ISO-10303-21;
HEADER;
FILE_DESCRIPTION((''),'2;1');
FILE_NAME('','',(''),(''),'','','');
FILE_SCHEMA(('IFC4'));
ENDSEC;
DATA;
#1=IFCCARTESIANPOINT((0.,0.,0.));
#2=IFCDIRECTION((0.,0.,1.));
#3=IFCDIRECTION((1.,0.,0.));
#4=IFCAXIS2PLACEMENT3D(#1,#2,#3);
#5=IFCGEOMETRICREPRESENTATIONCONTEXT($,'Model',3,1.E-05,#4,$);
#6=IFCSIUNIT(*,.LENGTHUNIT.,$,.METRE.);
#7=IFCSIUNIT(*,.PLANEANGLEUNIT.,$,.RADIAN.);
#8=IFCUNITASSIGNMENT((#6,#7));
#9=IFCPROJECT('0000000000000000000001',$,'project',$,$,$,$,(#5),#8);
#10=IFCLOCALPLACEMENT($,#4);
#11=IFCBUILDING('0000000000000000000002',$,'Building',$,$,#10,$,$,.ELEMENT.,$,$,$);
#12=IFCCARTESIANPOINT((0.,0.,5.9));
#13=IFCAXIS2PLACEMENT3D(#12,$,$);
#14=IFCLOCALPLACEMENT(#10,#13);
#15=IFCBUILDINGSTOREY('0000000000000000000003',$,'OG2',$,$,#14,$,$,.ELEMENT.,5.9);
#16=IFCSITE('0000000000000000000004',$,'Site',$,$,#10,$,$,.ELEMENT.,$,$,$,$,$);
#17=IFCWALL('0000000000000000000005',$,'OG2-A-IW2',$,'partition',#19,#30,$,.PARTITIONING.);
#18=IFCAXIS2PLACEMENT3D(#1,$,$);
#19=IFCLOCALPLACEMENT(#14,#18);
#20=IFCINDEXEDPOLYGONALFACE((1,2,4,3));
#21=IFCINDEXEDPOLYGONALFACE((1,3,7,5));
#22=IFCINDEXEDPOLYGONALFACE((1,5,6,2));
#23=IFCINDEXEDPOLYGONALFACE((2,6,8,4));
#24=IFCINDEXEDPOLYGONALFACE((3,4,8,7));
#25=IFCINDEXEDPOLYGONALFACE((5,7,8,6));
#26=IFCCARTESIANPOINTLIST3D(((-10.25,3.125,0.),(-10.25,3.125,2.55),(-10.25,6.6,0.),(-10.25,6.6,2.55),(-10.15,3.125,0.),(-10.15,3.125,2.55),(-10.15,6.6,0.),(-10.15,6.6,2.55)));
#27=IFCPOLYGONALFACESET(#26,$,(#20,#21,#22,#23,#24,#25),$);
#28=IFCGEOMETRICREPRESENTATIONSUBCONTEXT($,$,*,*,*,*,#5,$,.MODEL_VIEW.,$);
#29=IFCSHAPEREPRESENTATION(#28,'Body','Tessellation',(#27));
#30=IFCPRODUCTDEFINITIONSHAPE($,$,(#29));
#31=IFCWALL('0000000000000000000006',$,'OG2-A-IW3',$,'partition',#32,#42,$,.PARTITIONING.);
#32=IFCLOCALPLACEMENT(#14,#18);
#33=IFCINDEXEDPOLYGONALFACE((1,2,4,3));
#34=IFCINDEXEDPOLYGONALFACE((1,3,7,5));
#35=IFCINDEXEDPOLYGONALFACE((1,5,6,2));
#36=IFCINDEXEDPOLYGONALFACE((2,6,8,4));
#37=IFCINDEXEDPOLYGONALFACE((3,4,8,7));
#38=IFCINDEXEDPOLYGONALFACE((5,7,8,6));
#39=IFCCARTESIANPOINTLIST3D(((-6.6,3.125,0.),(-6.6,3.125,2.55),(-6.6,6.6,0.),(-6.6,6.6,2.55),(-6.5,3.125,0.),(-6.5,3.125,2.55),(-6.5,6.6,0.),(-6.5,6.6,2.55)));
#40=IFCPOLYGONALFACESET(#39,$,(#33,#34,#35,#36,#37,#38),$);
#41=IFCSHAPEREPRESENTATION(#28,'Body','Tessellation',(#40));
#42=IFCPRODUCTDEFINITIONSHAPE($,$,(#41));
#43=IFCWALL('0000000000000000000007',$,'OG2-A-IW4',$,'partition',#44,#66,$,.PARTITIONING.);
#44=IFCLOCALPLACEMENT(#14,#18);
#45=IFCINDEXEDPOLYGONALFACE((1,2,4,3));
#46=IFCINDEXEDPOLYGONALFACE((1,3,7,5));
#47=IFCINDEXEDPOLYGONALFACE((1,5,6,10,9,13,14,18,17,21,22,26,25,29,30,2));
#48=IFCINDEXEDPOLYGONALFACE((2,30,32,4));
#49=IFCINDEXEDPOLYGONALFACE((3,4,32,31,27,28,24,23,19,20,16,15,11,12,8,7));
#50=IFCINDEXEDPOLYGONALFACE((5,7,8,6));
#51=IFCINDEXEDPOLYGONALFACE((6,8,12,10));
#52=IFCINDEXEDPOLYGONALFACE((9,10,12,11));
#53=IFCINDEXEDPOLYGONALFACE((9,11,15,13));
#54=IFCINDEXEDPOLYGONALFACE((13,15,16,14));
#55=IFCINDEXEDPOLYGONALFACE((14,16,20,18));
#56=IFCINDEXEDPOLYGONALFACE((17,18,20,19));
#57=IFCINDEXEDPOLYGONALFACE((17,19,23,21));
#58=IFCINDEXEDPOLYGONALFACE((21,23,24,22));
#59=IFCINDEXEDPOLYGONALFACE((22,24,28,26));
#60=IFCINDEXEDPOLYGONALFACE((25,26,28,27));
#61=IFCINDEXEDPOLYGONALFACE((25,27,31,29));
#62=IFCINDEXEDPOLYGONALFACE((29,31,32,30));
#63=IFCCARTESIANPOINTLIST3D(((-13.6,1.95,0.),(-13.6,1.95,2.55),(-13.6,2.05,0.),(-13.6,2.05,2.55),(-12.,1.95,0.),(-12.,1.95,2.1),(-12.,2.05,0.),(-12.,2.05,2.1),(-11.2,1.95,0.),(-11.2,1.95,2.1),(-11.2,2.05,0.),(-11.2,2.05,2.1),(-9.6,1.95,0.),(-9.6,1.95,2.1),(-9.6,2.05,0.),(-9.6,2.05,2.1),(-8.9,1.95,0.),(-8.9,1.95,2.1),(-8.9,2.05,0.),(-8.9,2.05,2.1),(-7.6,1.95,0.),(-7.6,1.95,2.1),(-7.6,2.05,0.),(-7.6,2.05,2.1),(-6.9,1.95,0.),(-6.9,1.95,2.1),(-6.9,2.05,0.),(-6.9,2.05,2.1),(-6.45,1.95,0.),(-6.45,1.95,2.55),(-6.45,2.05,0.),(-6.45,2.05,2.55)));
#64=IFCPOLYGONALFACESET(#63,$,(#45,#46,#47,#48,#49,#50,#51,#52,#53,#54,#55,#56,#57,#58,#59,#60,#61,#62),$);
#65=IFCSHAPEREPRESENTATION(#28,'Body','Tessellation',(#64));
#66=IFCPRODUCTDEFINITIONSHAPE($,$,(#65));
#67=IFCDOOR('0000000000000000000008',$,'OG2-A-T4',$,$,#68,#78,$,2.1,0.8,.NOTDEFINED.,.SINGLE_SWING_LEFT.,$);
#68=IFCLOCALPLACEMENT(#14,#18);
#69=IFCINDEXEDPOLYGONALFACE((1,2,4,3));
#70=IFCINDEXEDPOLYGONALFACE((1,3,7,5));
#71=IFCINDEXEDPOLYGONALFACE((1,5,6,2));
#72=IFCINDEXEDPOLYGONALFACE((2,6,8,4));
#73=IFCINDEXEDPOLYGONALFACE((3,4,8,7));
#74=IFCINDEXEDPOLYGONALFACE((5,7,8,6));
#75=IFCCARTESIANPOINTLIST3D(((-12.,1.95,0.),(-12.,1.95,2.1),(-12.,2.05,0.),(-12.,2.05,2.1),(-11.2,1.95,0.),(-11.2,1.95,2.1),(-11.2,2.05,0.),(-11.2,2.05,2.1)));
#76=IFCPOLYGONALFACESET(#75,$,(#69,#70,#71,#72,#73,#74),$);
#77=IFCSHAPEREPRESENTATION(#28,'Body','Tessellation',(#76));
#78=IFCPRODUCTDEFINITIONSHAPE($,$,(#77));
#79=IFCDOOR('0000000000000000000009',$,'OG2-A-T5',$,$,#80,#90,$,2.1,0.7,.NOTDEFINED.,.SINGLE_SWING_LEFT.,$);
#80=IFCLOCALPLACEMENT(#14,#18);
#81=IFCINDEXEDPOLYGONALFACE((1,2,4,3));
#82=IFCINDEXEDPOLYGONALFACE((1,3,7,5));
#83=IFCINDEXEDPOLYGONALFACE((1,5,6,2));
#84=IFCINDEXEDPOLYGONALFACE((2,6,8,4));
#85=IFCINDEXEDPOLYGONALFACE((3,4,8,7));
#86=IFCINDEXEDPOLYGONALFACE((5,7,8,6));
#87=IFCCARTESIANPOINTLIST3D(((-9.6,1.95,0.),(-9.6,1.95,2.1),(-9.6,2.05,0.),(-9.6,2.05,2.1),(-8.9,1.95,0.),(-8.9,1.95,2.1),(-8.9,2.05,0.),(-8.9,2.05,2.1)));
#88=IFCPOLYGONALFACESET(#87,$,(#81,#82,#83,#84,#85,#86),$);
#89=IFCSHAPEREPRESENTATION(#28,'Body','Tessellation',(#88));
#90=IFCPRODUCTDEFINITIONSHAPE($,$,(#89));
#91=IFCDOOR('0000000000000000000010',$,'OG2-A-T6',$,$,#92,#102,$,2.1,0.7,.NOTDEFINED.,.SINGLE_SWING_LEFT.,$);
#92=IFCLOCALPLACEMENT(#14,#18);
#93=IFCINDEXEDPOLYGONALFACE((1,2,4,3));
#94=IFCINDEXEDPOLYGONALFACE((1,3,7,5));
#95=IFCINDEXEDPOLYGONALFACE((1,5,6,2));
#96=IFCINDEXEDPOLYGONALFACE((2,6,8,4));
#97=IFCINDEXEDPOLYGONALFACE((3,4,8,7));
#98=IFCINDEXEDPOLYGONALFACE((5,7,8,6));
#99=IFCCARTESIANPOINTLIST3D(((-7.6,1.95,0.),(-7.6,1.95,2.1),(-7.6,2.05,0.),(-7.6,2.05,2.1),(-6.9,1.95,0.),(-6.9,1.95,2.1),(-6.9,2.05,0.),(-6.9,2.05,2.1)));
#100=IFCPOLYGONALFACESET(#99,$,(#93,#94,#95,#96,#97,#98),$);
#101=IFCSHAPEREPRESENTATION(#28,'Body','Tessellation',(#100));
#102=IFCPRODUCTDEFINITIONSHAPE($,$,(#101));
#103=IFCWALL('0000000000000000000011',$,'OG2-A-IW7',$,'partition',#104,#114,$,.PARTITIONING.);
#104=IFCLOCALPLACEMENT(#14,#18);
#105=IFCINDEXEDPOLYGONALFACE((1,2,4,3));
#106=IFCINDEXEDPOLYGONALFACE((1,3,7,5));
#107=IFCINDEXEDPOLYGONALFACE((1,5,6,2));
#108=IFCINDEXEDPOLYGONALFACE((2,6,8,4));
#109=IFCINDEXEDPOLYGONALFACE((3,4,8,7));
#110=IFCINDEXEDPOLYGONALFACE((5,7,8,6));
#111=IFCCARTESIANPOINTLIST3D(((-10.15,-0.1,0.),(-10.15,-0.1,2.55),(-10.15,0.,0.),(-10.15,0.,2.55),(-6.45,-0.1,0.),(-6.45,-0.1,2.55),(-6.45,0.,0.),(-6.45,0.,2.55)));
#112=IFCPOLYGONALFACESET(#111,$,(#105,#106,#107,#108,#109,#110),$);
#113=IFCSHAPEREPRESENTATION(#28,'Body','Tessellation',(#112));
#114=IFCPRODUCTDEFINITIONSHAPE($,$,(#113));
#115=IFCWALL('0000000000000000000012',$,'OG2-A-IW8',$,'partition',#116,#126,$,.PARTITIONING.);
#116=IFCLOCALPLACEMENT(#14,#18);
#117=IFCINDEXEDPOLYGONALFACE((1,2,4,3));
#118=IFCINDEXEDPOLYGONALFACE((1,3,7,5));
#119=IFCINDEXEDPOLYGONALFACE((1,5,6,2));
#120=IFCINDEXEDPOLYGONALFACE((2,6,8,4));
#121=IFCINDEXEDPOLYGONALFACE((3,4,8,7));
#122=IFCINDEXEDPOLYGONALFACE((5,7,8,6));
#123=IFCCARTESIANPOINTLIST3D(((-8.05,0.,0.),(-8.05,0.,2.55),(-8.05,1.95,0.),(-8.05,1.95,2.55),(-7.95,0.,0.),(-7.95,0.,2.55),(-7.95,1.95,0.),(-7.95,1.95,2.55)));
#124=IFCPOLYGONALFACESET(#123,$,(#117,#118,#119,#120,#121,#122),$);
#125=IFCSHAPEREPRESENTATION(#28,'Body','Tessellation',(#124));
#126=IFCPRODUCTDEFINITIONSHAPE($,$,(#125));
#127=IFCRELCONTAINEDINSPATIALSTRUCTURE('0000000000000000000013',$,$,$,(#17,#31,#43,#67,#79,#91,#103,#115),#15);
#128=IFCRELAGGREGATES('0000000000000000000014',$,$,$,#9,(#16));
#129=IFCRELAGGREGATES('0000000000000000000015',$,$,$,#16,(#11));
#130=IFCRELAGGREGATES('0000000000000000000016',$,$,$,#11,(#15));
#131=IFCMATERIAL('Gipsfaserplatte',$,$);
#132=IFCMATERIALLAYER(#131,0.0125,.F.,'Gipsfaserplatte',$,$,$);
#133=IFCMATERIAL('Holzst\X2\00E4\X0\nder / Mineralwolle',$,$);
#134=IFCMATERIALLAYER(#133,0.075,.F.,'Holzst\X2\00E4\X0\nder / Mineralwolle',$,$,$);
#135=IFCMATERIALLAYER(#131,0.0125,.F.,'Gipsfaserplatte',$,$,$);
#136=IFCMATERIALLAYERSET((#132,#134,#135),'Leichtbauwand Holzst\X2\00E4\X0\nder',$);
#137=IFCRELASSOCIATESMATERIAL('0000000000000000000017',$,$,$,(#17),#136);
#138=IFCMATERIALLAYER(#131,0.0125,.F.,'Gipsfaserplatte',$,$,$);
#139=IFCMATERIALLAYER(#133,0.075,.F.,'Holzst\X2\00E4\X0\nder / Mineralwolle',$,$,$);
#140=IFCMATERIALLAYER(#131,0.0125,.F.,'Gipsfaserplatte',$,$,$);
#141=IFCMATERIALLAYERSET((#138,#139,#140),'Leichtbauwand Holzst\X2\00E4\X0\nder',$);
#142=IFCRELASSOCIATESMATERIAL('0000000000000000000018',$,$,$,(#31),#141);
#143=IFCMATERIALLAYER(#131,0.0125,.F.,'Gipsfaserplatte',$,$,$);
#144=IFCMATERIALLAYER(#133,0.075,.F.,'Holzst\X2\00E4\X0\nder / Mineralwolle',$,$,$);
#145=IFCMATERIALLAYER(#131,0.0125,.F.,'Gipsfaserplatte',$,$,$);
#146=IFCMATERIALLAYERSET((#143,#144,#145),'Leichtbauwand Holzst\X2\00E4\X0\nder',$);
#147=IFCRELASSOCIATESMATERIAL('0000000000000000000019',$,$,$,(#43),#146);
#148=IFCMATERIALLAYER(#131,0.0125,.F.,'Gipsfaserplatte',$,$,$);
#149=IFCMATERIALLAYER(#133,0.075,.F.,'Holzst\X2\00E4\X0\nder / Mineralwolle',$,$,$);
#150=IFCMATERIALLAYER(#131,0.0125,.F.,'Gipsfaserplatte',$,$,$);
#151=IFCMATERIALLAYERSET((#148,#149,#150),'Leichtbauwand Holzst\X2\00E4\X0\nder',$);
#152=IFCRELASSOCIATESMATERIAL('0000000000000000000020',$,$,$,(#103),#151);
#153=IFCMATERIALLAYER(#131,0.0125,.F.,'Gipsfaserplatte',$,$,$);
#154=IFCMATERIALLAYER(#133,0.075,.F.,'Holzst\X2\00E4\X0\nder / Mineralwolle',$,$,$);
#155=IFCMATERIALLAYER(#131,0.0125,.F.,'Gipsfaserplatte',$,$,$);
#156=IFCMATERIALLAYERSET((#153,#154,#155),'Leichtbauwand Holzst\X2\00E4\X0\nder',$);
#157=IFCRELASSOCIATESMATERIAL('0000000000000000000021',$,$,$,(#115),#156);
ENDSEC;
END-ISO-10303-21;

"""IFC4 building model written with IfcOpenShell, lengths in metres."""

from ifc_helpers import new_model, si_unit, frame, frame_2d, origin, origin_with_axes, place, context, subcontext, project, spatial, rectangle, extrude, material, layer, layer_set, element, fill, save


model = new_model("IFC4")

# Units and contexts
model_context = context("Model", 3, precision=1e-05, world=origin_with_axes())
sub_context = subcontext(model_context, None, None, "MODEL_VIEW")
ifc_project = project(units=[si_unit("LENGTHUNIT", "METRE"), si_unit("PLANEANGLEUNIT", "RADIAN")], contexts=[model_context])

# Site, building, storey
placement = place(None, origin_with_axes())
site = spatial("IfcSite", under=ifc_project, at=placement, Name="Site", CompositionType="ELEMENT")
building = spatial("IfcBuilding", under=site, at=placement, Name="Building", CompositionType="ELEMENT")
storey_placement = place(placement, frame((0.0, 0.0, 5.9)))
storey = spatial("IfcBuildingStorey", under=building, at=storey_placement, Name="OG2", CompositionType="ELEMENT", Elevation=5.9)

# Shared definitions
ifc_material_1 = material(Name="Gipsfaserplatte")

# Walls
ifc_layer_1 = layer(ifc_material_1, 0.0125, ventilated=False, Name="Gipsfaserplatte")
ifc_material_2 = material(Name="Holzständer / Mineralwolle")
ifc_layer_2 = layer(ifc_material_2, 0.075, ventilated=False, Name="Holzständer / Mineralwolle")
ifc_layer_3 = layer(ifc_material_1, 0.0125, ventilated=False, Name="Gipsfaserplatte")
ifc_layer_set_1 = layer_set([ifc_layer_1, ifc_layer_2, ifc_layer_3], Name="Leichtbauwand Holzständer")
wall_1_placement = place(storey_placement, frame((-10.2, 3.125, 0.0), z_axis=(0.0, 0.0, 1.0), x_axis=(0.0, 1.0, 0.0)))
element("IfcWall", 1, at=wall_1_placement, inside=storey, material=ifc_layer_set_1, Name="OG2-A-IW2", ObjectType="partition", PredefinedType="PARTITIONING", context=sub_context, shape_type="SweptSolid", body=[
    extrude(rectangle(XDim=3.475, YDim=0.1, at=frame_2d((1.7375, 0.0))), origin(), (0.0, 0.0, 1.0), 2.55),
])
ifc_layer_4 = layer(ifc_material_1, 0.0125, ventilated=False, Name="Gipsfaserplatte")
ifc_layer_5 = layer(ifc_material_2, 0.075, ventilated=False, Name="Holzständer / Mineralwolle")
ifc_layer_6 = layer(ifc_material_1, 0.0125, ventilated=False, Name="Gipsfaserplatte")
ifc_layer_set_2 = layer_set([ifc_layer_4, ifc_layer_5, ifc_layer_6], Name="Leichtbauwand Holzständer")
wall_2_placement = place(storey_placement, frame((-6.55, 3.125, 0.0), z_axis=(0.0, 0.0, 1.0), x_axis=(0.0, 1.0, 0.0)))
element("IfcWall", 2, at=wall_2_placement, inside=storey, material=ifc_layer_set_2, Name="OG2-A-IW3", ObjectType="partition", PredefinedType="PARTITIONING", context=sub_context, shape_type="SweptSolid", body=[
    extrude(rectangle(XDim=3.475, YDim=0.1, at=frame_2d((1.7375, 0.0))), origin(), (0.0, 0.0, 1.0), 2.55),
])

# Wall, openings, doors
ifc_layer_7 = layer(ifc_material_1, 0.0125, ventilated=False, Name="Gipsfaserplatte")
ifc_layer_8 = layer(ifc_material_2, 0.075, ventilated=False, Name="Holzständer / Mineralwolle")
ifc_layer_9 = layer(ifc_material_1, 0.0125, ventilated=False, Name="Gipsfaserplatte")
ifc_layer_set_3 = layer_set([ifc_layer_7, ifc_layer_8, ifc_layer_9], Name="Leichtbauwand Holzständer")
wall_3_placement = place(storey_placement, frame((-13.6, 2.0, 0.0), z_axis=(0.0, 0.0, 1.0), x_axis=(1.0, 0.0, 0.0)))
wall_3 = element("IfcWall", 3, at=wall_3_placement, inside=storey, material=ifc_layer_set_3, Name="OG2-A-IW4", ObjectType="partition", PredefinedType="PARTITIONING", context=sub_context, shape_type="SweptSolid", body=[
    extrude(rectangle(XDim=7.15, YDim=0.1, at=frame_2d((3.575, 0.0))), origin(), (0.0, 0.0, 1.0), 2.55),
])
opening_1_placement = place(wall_3_placement, frame((2.0, 0.1, 0.0), z_axis=(0.0, -1.0, 0.0), x_axis=(1.0, 0.0, 0.0)))
opening_1 = element("IfcOpeningElement", 4, at=opening_1_placement, cuts=wall_3, PredefinedType="OPENING", context=sub_context, shape_type="SweptSolid", body=[
    extrude(rectangle(XDim=0.8, YDim=2.1, at=frame_2d((0.0, 1.05))), origin(), (0.0, 0.0, 1.0), 0.2),
])
opening_2_placement = place(wall_3_placement, frame((4.35, 0.1, 0.0), z_axis=(0.0, -1.0, 0.0), x_axis=(1.0, 0.0, 0.0)))
opening_2 = element("IfcOpeningElement", 5, at=opening_2_placement, cuts=wall_3, PredefinedType="OPENING", context=sub_context, shape_type="SweptSolid", body=[
    extrude(rectangle(XDim=0.7, YDim=2.1, at=frame_2d((0.0, 1.05))), origin(), (0.0, 0.0, 1.0), 0.2),
])
opening_3_placement = place(wall_3_placement, frame((6.35, 0.1, 0.0), z_axis=(0.0, -1.0, 0.0), x_axis=(1.0, 0.0, 0.0)))
opening_3 = element("IfcOpeningElement", 6, at=opening_3_placement, cuts=wall_3, PredefinedType="OPENING", context=sub_context, shape_type="SweptSolid", body=[
    extrude(rectangle(XDim=0.7, YDim=2.1, at=frame_2d((0.0, 1.05))), origin(), (0.0, 0.0, 1.0), 0.2),
])
door_1_placement = place(wall_3_placement, frame((2.0, 0.05, 0.0), z_axis=(0.0, -1.0, 0.0), x_axis=(1.0, 0.0, 0.0)))
door_1 = element("IfcDoor", 7, at=door_1_placement, inside=storey, Name="OG2-A-T4", OperationType="SINGLE_SWING_LEFT", OverallHeight=2.1, OverallWidth=0.8, PredefinedType="NOTDEFINED", context=sub_context, shape_type="SweptSolid", body=[
    extrude(rectangle(XDim=0.8, YDim=2.1, at=frame_2d((0.0, 1.05))), origin(), (0.0, 0.0, 1.0), 0.1),
])
fill(opening_1, door_1)
door_2_placement = place(wall_3_placement, frame((4.35, 0.05, 0.0), z_axis=(0.0, -1.0, 0.0), x_axis=(1.0, 0.0, 0.0)))
door_2 = element("IfcDoor", 8, at=door_2_placement, inside=storey, Name="OG2-A-T5", OperationType="SINGLE_SWING_LEFT", OverallHeight=2.1, OverallWidth=0.7, PredefinedType="NOTDEFINED", context=sub_context, shape_type="SweptSolid", body=[
    extrude(rectangle(XDim=0.7, YDim=2.1, at=frame_2d((0.0, 1.05))), origin(), (0.0, 0.0, 1.0), 0.1),
])
fill(opening_2, door_2)
door_3_placement = place(wall_3_placement, frame((6.35, 0.05, 0.0), z_axis=(0.0, -1.0, 0.0), x_axis=(1.0, 0.0, 0.0)))
door_3 = element("IfcDoor", 9, at=door_3_placement, inside=storey, Name="OG2-A-T6", OperationType="SINGLE_SWING_LEFT", OverallHeight=2.1, OverallWidth=0.7, PredefinedType="NOTDEFINED", context=sub_context, shape_type="SweptSolid", body=[
    extrude(rectangle(XDim=0.7, YDim=2.1, at=frame_2d((0.0, 1.05))), origin(), (0.0, 0.0, 1.0), 0.1),
])
fill(opening_3, door_3)

# Walls
ifc_layer_10 = layer(ifc_material_1, 0.0125, ventilated=False, Name="Gipsfaserplatte")
ifc_layer_11 = layer(ifc_material_2, 0.075, ventilated=False, Name="Holzständer / Mineralwolle")
ifc_layer_12 = layer(ifc_material_1, 0.0125, ventilated=False, Name="Gipsfaserplatte")
ifc_layer_set_4 = layer_set([ifc_layer_10, ifc_layer_11, ifc_layer_12], Name="Leichtbauwand Holzständer")
wall_4_placement = place(storey_placement, frame((-10.15, -0.05, 0.0), z_axis=(0.0, 0.0, 1.0), x_axis=(1.0, 0.0, 0.0)))
element("IfcWall", 10, at=wall_4_placement, inside=storey, material=ifc_layer_set_4, Name="OG2-A-IW7", ObjectType="partition", PredefinedType="PARTITIONING", context=sub_context, shape_type="SweptSolid", body=[
    extrude(rectangle(XDim=3.7, YDim=0.1, at=frame_2d((1.85, 0.0))), origin(), (0.0, 0.0, 1.0), 2.55),
])
ifc_layer_13 = layer(ifc_material_1, 0.0125, ventilated=False, Name="Gipsfaserplatte")
ifc_layer_14 = layer(ifc_material_2, 0.075, ventilated=False, Name="Holzständer / Mineralwolle")
ifc_layer_15 = layer(ifc_material_1, 0.0125, ventilated=False, Name="Gipsfaserplatte")
ifc_layer_set_5 = layer_set([ifc_layer_13, ifc_layer_14, ifc_layer_15], Name="Leichtbauwand Holzständer")
wall_5_placement = place(storey_placement, frame((-8.0, 0.0, 0.0), z_axis=(0.0, 0.0, 1.0), x_axis=(0.0, 1.0, 0.0)))
element("IfcWall", 11, at=wall_5_placement, inside=storey, material=ifc_layer_set_5, Name="OG2-A-IW8", ObjectType="partition", PredefinedType="PARTITIONING", context=sub_context, shape_type="SweptSolid", body=[
    extrude(rectangle(XDim=1.95, YDim=0.1, at=frame_2d((0.975, 0.0))), origin(), (0.0, 0.0, 1.0), 2.55),
])

save(model, "model.ifc")
